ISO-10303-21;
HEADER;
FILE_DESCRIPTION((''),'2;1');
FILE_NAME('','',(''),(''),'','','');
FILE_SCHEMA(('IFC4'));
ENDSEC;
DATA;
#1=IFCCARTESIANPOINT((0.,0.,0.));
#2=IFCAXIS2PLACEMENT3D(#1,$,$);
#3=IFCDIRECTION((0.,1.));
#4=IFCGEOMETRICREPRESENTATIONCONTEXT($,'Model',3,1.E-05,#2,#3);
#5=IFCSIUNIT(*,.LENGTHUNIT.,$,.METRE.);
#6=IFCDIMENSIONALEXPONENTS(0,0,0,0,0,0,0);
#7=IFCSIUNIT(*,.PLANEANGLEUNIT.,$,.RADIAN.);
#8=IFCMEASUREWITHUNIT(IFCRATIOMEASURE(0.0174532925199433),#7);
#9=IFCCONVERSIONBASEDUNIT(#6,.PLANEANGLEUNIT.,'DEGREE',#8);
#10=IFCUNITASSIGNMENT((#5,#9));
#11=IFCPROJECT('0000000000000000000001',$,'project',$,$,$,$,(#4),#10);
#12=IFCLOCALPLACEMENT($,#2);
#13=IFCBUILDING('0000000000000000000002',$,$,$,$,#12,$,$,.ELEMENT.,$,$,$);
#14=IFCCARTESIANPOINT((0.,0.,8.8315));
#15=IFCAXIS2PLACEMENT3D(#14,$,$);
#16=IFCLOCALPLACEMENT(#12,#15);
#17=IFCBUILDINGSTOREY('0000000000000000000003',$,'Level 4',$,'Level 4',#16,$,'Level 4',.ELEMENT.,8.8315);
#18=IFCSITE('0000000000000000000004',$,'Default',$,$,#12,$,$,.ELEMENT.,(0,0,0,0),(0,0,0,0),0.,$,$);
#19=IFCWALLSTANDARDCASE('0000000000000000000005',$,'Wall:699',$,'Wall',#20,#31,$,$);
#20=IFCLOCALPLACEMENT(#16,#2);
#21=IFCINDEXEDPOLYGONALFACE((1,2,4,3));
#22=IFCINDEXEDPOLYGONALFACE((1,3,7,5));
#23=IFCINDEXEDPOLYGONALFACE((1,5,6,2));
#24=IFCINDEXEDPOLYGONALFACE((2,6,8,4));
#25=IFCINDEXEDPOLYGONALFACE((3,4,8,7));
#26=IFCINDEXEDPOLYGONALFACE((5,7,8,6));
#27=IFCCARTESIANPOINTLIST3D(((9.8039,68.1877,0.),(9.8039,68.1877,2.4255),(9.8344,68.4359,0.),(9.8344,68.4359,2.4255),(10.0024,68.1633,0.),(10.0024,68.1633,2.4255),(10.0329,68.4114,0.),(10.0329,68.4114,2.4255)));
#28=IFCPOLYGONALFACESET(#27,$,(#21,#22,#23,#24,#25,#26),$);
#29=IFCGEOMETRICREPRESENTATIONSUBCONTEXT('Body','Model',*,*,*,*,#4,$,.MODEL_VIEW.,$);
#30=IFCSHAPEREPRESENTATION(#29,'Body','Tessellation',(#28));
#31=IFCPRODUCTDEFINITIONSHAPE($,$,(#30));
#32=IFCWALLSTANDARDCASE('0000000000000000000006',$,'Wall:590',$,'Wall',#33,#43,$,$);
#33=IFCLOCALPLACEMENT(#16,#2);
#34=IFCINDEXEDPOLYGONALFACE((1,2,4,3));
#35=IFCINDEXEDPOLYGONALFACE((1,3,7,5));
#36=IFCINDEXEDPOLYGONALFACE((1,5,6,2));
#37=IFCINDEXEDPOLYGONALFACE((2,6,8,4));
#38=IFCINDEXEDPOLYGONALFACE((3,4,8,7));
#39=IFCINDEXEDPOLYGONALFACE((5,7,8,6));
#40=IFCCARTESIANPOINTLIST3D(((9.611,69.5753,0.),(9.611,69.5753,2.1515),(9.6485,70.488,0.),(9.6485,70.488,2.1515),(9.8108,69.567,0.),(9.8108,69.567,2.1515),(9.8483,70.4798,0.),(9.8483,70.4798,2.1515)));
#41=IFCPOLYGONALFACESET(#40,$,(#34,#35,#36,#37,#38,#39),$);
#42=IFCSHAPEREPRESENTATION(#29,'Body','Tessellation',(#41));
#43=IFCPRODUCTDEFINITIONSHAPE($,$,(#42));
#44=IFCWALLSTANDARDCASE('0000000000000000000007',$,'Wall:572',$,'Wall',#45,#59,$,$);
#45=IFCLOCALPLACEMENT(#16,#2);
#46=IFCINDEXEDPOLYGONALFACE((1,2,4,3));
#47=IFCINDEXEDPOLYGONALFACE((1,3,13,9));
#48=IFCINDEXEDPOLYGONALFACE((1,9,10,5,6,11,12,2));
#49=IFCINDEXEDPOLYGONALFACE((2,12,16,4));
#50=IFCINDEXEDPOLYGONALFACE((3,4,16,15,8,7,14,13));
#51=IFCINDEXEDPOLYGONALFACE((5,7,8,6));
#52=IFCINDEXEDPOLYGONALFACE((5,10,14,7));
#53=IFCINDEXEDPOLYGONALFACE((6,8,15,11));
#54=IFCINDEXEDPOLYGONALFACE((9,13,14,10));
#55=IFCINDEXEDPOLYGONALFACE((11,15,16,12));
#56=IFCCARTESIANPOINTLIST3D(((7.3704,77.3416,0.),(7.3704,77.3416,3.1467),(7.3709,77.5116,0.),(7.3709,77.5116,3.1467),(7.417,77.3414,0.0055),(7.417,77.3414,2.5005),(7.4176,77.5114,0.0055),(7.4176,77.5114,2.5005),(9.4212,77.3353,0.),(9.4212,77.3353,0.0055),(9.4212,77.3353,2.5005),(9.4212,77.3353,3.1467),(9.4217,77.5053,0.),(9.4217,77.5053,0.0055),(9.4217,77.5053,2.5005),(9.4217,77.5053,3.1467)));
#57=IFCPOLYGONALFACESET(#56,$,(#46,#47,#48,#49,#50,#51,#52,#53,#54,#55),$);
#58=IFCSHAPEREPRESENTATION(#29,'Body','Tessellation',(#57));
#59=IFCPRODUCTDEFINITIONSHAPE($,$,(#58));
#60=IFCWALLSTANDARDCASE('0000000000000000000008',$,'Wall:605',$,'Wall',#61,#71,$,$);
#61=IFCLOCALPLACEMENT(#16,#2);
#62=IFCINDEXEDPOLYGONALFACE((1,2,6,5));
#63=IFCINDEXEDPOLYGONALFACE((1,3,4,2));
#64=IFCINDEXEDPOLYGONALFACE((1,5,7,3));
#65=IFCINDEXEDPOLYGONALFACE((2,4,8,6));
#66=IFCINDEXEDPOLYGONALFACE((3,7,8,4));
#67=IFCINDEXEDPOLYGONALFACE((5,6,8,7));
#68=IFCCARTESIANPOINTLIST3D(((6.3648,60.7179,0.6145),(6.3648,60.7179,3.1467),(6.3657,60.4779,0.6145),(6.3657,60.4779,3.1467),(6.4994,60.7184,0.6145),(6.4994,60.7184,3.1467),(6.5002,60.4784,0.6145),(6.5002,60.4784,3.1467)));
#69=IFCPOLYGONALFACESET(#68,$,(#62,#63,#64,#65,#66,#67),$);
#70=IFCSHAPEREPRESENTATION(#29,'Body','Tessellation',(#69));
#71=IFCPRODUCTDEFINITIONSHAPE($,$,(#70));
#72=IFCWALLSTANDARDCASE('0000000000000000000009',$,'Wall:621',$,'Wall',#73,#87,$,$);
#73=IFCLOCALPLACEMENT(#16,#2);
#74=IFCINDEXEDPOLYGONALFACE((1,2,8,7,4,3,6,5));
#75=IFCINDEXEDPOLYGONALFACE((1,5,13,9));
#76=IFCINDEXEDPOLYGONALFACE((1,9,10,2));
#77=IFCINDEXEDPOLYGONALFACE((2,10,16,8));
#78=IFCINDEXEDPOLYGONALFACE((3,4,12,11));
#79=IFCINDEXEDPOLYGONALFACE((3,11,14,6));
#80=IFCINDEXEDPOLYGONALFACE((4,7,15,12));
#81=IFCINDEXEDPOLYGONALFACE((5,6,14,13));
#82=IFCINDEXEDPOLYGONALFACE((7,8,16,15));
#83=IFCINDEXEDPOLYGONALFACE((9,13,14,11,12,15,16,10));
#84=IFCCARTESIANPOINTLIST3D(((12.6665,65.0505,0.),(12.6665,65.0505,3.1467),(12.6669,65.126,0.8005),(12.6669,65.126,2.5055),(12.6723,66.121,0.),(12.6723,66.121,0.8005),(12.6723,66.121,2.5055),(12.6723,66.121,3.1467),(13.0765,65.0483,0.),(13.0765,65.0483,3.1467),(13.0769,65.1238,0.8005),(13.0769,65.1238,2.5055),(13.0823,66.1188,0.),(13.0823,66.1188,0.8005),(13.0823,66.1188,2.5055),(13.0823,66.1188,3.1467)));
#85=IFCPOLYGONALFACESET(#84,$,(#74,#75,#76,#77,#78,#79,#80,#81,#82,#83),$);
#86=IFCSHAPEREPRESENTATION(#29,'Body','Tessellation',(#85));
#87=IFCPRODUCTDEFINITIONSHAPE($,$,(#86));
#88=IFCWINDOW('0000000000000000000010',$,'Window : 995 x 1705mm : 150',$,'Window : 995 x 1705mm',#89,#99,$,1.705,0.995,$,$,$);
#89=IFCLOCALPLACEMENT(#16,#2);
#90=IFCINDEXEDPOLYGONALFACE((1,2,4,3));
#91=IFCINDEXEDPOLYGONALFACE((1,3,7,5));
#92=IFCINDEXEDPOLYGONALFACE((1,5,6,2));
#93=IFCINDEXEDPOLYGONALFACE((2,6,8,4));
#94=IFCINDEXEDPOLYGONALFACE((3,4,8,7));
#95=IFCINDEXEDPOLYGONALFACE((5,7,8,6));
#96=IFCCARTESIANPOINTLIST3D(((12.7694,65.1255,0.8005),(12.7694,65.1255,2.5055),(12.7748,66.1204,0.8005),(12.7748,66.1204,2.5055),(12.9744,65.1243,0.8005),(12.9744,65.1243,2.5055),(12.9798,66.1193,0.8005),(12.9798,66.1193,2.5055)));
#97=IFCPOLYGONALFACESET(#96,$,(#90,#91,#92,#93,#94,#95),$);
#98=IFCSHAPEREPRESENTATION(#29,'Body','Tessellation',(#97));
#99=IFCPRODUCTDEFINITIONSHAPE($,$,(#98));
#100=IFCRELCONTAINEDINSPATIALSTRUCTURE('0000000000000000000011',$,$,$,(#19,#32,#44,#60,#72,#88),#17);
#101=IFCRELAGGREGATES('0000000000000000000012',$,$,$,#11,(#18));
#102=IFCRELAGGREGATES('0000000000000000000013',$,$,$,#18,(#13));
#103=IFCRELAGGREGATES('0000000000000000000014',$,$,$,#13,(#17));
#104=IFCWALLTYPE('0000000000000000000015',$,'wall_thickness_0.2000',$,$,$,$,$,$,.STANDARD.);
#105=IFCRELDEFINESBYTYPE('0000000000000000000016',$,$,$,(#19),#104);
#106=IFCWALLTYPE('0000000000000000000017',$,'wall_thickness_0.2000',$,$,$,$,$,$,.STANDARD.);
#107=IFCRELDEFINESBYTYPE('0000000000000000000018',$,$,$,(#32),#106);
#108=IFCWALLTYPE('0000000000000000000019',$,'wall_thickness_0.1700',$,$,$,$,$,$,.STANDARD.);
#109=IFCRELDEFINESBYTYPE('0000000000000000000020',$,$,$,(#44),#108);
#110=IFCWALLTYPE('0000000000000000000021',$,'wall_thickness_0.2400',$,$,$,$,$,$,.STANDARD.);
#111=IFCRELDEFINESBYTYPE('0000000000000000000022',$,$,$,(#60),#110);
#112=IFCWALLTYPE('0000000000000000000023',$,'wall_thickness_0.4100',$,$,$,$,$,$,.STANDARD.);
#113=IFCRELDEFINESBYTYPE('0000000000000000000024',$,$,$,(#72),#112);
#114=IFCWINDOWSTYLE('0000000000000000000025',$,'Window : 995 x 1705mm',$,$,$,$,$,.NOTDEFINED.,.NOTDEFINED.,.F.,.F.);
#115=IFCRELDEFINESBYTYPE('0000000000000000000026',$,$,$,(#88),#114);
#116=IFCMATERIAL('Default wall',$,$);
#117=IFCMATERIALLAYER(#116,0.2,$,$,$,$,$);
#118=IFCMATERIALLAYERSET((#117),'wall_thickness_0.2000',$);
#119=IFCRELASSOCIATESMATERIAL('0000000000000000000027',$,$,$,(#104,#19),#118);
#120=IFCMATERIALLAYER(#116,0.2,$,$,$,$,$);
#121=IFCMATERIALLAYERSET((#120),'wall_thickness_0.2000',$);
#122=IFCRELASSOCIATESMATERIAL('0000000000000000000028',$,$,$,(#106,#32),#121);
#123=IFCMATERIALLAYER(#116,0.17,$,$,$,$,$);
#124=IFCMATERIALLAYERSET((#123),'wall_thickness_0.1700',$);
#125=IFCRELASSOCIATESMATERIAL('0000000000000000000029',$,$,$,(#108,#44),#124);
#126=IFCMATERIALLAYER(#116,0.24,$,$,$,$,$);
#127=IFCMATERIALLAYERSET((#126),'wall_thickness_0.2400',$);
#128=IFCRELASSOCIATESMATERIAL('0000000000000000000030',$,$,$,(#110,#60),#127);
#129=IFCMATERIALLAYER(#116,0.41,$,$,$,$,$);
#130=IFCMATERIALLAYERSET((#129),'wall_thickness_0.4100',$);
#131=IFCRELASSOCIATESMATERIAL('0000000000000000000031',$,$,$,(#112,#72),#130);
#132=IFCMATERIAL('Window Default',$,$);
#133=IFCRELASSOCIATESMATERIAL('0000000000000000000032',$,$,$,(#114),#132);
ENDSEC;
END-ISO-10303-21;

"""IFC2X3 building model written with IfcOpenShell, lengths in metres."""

from ifc_helpers import new_model, entity, si_unit, converted_unit, direction, frame, frame_2d, origin, origin_2d_with_axis, place, context, subcontext, project, spatial, polyline, rectangle, outline, extrude, source, transform, mapped, material, layer, layer_set, layer_usage, type_object, type_shapes, element, fill, save


model = new_model("IFC2X3")

# Units and contexts
model_context = context("Model", 3, precision=1e-05, world=origin(), true_north=direction((0.0, 1.0)))
body_context = subcontext(model_context, "Body", "Model", "MODEL_VIEW")
ifc_project = project(units=[si_unit("LENGTHUNIT", "METRE"), converted_unit("PLANEANGLEUNIT", "DEGREE", entity("IfcRatioMeasure", 0.0174532925199433), si_unit("PLANEANGLEUNIT", "RADIAN"), dimensions=[0, 0, 0, 0, 0, 0, 0])], contexts=[model_context])

# Site, building, storey
placement_1 = place(None, origin())
site = spatial("IfcSite", under=ifc_project, at=placement_1, Name="Default", CompositionType="ELEMENT", RefLatitude=(0, 0, 0, 0), RefLongitude=(0, 0, 0, 0), RefElevation=0.0)
building = spatial("IfcBuilding", under=site, at=placement_1, CompositionType="ELEMENT")
storey_placement = place(placement_1, frame((0.0, 0.0, 8.8315)))
storey = spatial("IfcBuildingStorey", under=building, at=storey_placement, Name="Level 4", ObjectType="Level 4", LongName="Level 4", CompositionType="ELEMENT", Elevation=8.8315)

# Shared definitions
ifc_material_1 = material(Name="Default wall")
ifc_material_2 = material(Name="Window Default")

# Walls
ifc_layer_1 = layer(ifc_material_1, 0.2)
ifc_layer_set_1 = layer_set([ifc_layer_1], Name="wall_thickness_0.2000")
ifc_layer_usage_1 = layer_usage(ifc_layer_set_1, "AXIS2", "POSITIVE", -0.1)
wall_type_1 = type_object("IfcWallType", Name="wall_thickness_0.2000", PredefinedType="STANDARD", material=ifc_layer_set_1)
wall_1_placement = place(storey_placement, frame((9.9336, 68.4236, 0.0), z_axis=(0.0, 0.0, 1.0), x_axis=(-0.122081, -0.99252, 0.0)))
element("IfcWallStandardCase", 1, at=wall_1_placement, inside=storey, type_object=wall_type_1, material=ifc_layer_usage_1, Name="Wall:699", ObjectType="Wall", context=body_context, shape_type="SweptSolid", body=[
    extrude(outline(polyline([(0.25, -0.1), (0.25, 0.1), (0.0, 0.1), (0.0, -0.1), (0.25, -0.1)])), origin(), (0.0, 0.0, 1.0), 2.4255),
])
ifc_layer_2 = layer(ifc_material_1, 0.2)
ifc_layer_set_2 = layer_set([ifc_layer_2], Name="wall_thickness_0.2000")
ifc_layer_usage_2 = layer_usage(ifc_layer_set_2, "AXIS2", "POSITIVE", -0.1)
wall_type_2 = type_object("IfcWallType", Name="wall_thickness_0.2000", PredefinedType="STANDARD", material=ifc_layer_set_2)
wall_2_placement = place(storey_placement, frame((9.7484, 70.4839, 0.0), z_axis=(0.0, 0.0, 1.0), x_axis=(-0.041116, -0.999154, 0.0)))
element("IfcWallStandardCase", 2, at=wall_2_placement, inside=storey, type_object=wall_type_2, material=ifc_layer_usage_2, Name="Wall:590", ObjectType="Wall", context=body_context, shape_type="SweptSolid", body=[
    extrude(outline(polyline([(0.9135, -0.1), (0.9135, 0.1), (0.0, 0.1), (0.0, -0.1), (0.9135, -0.1)])), origin(), (0.0, 0.0, 1.0), 2.1515),
])

# Wall, opening
ifc_layer_3 = layer(ifc_material_1, 0.17)
ifc_layer_set_3 = layer_set([ifc_layer_3], Name="wall_thickness_0.1700")
ifc_layer_usage_3 = layer_usage(ifc_layer_set_3, "AXIS2", "POSITIVE", -0.085)
wall_type_3 = type_object("IfcWallType", Name="wall_thickness_0.1700", PredefinedType="STANDARD", material=ifc_layer_set_3)
wall_3_placement = place(storey_placement, frame((7.3707, 77.4266, 0.0), z_axis=(0.0, 0.0, 1.0), x_axis=(0.999995, -0.003051, 0.0)))
wall_3 = element("IfcWallStandardCase", 3, at=wall_3_placement, inside=storey, type_object=wall_type_3, material=ifc_layer_usage_3, Name="Wall:572", ObjectType="Wall", context=body_context, shape_type="SweptSolid", body=[
    extrude(outline(polyline([(2.0508, -0.085), (2.0508, 0.085), (0.0, 0.085), (0.0, -0.085), (2.0508, -0.085)])), origin(), (0.0, 0.0, 1.0), 3.1467),
])
opening_1_placement = place(wall_3_placement, frame((0.0466, -0.085, 0.0055)))
element("IfcOpeningElement", 4, at=opening_1_placement, cuts=wall_3, ObjectType="Opening", context=body_context, shape_type="SweptSolid", body=[
    extrude(rectangle(XDim=2.02, YDim=2.495, at=frame_2d((1.2475, 1.01), x_axis=(0.0, 1.0))), frame((0.0, 0.0, 0.0), z_axis=(0.0, 1.0, 0.0), x_axis=(0.0, 0.0, 1.0)), (0.0, 0.0, 1.0), 0.17),
])

# Wall
ifc_layer_4 = layer(ifc_material_1, 0.24)
ifc_layer_set_4 = layer_set([ifc_layer_4], Name="wall_thickness_0.2400")
ifc_layer_usage_4 = layer_usage(ifc_layer_set_4, "AXIS2", "POSITIVE", -0.12)
wall_type_4 = type_object("IfcWallType", Name="wall_thickness_0.2400", PredefinedType="STANDARD", material=ifc_layer_set_4)
placement_2 = place(placement_1, frame((0.0, 0.0, 9.446)))
wall_4_placement = place(placement_2, frame((6.3653, 60.5979, 0.0), z_axis=(0.0, 0.0, 1.0), x_axis=(0.999993, 0.003743, 0.0)))
element("IfcWallStandardCase", 5, at=wall_4_placement, inside=storey, type_object=wall_type_4, material=ifc_layer_usage_4, Name="Wall:605", ObjectType="Wall", context=body_context, shape_type="SweptSolid", body=[
    extrude(outline(polyline([(0.1345, -0.12), (0.1345, 0.12), (0.0, 0.12), (0.0, -0.12), (0.1345, -0.12)])), origin(), (0.0, 0.0, 1.0), 2.5322),
])

# Wall, opening, window
ifc_layer_5 = layer(ifc_material_1, 0.41)
ifc_layer_set_5 = layer_set([ifc_layer_5], Name="wall_thickness_0.4100")
ifc_layer_usage_5 = layer_usage(ifc_layer_set_5, "AXIS2", "POSITIVE", -0.205)
wall_type_5 = type_object("IfcWallType", Name="wall_thickness_0.4100", PredefinedType="STANDARD", material=ifc_layer_set_5)
wall_5_placement = place(storey_placement, frame((12.8773, 66.1199, 0.0), z_axis=(0.0, 0.0, 1.0), x_axis=(-0.005466, -0.999985, 0.0)))
wall_5 = element("IfcWallStandardCase", 6, at=wall_5_placement, inside=storey, type_object=wall_type_5, material=ifc_layer_usage_5, Name="Wall:621", ObjectType="Wall", context=body_context, shape_type="SweptSolid", body=[
    extrude(outline(polyline([(1.0705, -0.205), (1.0705, 0.205), (0.0, 0.205), (0.0, -0.205), (1.0705, -0.205)])), origin(), (0.0, 0.0, 1.0), 3.1467),
])
opening_2_placement = place(wall_5_placement, frame((0.0, -0.205, 0.8005)))
opening_2 = element("IfcOpeningElement", 7, at=opening_2_placement, cuts=wall_5, ObjectType="Opening", context=body_context, shape_type="SweptSolid", body=[
    extrude(rectangle(XDim=0.995, YDim=1.705, at=frame_2d((0.8525, 0.4975), x_axis=(0.0, 1.0))), frame((0.0, 0.0, 0.0), z_axis=(0.0, 1.0, 0.0), x_axis=(0.0, 0.0, 1.0)), (0.0, 0.0, 1.0), 0.41),
])
window_style_1 = type_object("IfcWindowStyle", Name="Window : 995 x 1705mm", ConstructionType="NOTDEFINED", OperationType="NOTDEFINED", ParameterTakesPrecedence=False, Sizeable=False, material=ifc_material_2)
shared_shape_1 = source(origin(), body_context, "Body", "SweptSolid", [
    extrude(rectangle(XDim=0.205, YDim=0.995, at=origin_2d_with_axis()), frame((0.4975, 0.205, 0.0), z_axis=(0.0, 0.0, 1.0), x_axis=(0.0, 1.0, 0.0)), (0.0, 0.0, 1.0), 1.705),
])
type_shapes(window_style_1, [shared_shape_1])
window_1_placement = place(opening_2_placement, origin())
window_1 = element("IfcWindow", 8, at=window_1_placement, inside=storey, type_object=window_style_1, Name="Window : 995 x 1705mm : 150", ObjectType="Window : 995 x 1705mm", OverallHeight=1.705, OverallWidth=0.995, context=body_context, shape_type="MappedRepresentation", body=[
    mapped(shared_shape_1, transform((0.0, 0.0, 0.0), scale=1.0)),
])
fill(opening_2, window_1)

save(model, "model.ifc")
